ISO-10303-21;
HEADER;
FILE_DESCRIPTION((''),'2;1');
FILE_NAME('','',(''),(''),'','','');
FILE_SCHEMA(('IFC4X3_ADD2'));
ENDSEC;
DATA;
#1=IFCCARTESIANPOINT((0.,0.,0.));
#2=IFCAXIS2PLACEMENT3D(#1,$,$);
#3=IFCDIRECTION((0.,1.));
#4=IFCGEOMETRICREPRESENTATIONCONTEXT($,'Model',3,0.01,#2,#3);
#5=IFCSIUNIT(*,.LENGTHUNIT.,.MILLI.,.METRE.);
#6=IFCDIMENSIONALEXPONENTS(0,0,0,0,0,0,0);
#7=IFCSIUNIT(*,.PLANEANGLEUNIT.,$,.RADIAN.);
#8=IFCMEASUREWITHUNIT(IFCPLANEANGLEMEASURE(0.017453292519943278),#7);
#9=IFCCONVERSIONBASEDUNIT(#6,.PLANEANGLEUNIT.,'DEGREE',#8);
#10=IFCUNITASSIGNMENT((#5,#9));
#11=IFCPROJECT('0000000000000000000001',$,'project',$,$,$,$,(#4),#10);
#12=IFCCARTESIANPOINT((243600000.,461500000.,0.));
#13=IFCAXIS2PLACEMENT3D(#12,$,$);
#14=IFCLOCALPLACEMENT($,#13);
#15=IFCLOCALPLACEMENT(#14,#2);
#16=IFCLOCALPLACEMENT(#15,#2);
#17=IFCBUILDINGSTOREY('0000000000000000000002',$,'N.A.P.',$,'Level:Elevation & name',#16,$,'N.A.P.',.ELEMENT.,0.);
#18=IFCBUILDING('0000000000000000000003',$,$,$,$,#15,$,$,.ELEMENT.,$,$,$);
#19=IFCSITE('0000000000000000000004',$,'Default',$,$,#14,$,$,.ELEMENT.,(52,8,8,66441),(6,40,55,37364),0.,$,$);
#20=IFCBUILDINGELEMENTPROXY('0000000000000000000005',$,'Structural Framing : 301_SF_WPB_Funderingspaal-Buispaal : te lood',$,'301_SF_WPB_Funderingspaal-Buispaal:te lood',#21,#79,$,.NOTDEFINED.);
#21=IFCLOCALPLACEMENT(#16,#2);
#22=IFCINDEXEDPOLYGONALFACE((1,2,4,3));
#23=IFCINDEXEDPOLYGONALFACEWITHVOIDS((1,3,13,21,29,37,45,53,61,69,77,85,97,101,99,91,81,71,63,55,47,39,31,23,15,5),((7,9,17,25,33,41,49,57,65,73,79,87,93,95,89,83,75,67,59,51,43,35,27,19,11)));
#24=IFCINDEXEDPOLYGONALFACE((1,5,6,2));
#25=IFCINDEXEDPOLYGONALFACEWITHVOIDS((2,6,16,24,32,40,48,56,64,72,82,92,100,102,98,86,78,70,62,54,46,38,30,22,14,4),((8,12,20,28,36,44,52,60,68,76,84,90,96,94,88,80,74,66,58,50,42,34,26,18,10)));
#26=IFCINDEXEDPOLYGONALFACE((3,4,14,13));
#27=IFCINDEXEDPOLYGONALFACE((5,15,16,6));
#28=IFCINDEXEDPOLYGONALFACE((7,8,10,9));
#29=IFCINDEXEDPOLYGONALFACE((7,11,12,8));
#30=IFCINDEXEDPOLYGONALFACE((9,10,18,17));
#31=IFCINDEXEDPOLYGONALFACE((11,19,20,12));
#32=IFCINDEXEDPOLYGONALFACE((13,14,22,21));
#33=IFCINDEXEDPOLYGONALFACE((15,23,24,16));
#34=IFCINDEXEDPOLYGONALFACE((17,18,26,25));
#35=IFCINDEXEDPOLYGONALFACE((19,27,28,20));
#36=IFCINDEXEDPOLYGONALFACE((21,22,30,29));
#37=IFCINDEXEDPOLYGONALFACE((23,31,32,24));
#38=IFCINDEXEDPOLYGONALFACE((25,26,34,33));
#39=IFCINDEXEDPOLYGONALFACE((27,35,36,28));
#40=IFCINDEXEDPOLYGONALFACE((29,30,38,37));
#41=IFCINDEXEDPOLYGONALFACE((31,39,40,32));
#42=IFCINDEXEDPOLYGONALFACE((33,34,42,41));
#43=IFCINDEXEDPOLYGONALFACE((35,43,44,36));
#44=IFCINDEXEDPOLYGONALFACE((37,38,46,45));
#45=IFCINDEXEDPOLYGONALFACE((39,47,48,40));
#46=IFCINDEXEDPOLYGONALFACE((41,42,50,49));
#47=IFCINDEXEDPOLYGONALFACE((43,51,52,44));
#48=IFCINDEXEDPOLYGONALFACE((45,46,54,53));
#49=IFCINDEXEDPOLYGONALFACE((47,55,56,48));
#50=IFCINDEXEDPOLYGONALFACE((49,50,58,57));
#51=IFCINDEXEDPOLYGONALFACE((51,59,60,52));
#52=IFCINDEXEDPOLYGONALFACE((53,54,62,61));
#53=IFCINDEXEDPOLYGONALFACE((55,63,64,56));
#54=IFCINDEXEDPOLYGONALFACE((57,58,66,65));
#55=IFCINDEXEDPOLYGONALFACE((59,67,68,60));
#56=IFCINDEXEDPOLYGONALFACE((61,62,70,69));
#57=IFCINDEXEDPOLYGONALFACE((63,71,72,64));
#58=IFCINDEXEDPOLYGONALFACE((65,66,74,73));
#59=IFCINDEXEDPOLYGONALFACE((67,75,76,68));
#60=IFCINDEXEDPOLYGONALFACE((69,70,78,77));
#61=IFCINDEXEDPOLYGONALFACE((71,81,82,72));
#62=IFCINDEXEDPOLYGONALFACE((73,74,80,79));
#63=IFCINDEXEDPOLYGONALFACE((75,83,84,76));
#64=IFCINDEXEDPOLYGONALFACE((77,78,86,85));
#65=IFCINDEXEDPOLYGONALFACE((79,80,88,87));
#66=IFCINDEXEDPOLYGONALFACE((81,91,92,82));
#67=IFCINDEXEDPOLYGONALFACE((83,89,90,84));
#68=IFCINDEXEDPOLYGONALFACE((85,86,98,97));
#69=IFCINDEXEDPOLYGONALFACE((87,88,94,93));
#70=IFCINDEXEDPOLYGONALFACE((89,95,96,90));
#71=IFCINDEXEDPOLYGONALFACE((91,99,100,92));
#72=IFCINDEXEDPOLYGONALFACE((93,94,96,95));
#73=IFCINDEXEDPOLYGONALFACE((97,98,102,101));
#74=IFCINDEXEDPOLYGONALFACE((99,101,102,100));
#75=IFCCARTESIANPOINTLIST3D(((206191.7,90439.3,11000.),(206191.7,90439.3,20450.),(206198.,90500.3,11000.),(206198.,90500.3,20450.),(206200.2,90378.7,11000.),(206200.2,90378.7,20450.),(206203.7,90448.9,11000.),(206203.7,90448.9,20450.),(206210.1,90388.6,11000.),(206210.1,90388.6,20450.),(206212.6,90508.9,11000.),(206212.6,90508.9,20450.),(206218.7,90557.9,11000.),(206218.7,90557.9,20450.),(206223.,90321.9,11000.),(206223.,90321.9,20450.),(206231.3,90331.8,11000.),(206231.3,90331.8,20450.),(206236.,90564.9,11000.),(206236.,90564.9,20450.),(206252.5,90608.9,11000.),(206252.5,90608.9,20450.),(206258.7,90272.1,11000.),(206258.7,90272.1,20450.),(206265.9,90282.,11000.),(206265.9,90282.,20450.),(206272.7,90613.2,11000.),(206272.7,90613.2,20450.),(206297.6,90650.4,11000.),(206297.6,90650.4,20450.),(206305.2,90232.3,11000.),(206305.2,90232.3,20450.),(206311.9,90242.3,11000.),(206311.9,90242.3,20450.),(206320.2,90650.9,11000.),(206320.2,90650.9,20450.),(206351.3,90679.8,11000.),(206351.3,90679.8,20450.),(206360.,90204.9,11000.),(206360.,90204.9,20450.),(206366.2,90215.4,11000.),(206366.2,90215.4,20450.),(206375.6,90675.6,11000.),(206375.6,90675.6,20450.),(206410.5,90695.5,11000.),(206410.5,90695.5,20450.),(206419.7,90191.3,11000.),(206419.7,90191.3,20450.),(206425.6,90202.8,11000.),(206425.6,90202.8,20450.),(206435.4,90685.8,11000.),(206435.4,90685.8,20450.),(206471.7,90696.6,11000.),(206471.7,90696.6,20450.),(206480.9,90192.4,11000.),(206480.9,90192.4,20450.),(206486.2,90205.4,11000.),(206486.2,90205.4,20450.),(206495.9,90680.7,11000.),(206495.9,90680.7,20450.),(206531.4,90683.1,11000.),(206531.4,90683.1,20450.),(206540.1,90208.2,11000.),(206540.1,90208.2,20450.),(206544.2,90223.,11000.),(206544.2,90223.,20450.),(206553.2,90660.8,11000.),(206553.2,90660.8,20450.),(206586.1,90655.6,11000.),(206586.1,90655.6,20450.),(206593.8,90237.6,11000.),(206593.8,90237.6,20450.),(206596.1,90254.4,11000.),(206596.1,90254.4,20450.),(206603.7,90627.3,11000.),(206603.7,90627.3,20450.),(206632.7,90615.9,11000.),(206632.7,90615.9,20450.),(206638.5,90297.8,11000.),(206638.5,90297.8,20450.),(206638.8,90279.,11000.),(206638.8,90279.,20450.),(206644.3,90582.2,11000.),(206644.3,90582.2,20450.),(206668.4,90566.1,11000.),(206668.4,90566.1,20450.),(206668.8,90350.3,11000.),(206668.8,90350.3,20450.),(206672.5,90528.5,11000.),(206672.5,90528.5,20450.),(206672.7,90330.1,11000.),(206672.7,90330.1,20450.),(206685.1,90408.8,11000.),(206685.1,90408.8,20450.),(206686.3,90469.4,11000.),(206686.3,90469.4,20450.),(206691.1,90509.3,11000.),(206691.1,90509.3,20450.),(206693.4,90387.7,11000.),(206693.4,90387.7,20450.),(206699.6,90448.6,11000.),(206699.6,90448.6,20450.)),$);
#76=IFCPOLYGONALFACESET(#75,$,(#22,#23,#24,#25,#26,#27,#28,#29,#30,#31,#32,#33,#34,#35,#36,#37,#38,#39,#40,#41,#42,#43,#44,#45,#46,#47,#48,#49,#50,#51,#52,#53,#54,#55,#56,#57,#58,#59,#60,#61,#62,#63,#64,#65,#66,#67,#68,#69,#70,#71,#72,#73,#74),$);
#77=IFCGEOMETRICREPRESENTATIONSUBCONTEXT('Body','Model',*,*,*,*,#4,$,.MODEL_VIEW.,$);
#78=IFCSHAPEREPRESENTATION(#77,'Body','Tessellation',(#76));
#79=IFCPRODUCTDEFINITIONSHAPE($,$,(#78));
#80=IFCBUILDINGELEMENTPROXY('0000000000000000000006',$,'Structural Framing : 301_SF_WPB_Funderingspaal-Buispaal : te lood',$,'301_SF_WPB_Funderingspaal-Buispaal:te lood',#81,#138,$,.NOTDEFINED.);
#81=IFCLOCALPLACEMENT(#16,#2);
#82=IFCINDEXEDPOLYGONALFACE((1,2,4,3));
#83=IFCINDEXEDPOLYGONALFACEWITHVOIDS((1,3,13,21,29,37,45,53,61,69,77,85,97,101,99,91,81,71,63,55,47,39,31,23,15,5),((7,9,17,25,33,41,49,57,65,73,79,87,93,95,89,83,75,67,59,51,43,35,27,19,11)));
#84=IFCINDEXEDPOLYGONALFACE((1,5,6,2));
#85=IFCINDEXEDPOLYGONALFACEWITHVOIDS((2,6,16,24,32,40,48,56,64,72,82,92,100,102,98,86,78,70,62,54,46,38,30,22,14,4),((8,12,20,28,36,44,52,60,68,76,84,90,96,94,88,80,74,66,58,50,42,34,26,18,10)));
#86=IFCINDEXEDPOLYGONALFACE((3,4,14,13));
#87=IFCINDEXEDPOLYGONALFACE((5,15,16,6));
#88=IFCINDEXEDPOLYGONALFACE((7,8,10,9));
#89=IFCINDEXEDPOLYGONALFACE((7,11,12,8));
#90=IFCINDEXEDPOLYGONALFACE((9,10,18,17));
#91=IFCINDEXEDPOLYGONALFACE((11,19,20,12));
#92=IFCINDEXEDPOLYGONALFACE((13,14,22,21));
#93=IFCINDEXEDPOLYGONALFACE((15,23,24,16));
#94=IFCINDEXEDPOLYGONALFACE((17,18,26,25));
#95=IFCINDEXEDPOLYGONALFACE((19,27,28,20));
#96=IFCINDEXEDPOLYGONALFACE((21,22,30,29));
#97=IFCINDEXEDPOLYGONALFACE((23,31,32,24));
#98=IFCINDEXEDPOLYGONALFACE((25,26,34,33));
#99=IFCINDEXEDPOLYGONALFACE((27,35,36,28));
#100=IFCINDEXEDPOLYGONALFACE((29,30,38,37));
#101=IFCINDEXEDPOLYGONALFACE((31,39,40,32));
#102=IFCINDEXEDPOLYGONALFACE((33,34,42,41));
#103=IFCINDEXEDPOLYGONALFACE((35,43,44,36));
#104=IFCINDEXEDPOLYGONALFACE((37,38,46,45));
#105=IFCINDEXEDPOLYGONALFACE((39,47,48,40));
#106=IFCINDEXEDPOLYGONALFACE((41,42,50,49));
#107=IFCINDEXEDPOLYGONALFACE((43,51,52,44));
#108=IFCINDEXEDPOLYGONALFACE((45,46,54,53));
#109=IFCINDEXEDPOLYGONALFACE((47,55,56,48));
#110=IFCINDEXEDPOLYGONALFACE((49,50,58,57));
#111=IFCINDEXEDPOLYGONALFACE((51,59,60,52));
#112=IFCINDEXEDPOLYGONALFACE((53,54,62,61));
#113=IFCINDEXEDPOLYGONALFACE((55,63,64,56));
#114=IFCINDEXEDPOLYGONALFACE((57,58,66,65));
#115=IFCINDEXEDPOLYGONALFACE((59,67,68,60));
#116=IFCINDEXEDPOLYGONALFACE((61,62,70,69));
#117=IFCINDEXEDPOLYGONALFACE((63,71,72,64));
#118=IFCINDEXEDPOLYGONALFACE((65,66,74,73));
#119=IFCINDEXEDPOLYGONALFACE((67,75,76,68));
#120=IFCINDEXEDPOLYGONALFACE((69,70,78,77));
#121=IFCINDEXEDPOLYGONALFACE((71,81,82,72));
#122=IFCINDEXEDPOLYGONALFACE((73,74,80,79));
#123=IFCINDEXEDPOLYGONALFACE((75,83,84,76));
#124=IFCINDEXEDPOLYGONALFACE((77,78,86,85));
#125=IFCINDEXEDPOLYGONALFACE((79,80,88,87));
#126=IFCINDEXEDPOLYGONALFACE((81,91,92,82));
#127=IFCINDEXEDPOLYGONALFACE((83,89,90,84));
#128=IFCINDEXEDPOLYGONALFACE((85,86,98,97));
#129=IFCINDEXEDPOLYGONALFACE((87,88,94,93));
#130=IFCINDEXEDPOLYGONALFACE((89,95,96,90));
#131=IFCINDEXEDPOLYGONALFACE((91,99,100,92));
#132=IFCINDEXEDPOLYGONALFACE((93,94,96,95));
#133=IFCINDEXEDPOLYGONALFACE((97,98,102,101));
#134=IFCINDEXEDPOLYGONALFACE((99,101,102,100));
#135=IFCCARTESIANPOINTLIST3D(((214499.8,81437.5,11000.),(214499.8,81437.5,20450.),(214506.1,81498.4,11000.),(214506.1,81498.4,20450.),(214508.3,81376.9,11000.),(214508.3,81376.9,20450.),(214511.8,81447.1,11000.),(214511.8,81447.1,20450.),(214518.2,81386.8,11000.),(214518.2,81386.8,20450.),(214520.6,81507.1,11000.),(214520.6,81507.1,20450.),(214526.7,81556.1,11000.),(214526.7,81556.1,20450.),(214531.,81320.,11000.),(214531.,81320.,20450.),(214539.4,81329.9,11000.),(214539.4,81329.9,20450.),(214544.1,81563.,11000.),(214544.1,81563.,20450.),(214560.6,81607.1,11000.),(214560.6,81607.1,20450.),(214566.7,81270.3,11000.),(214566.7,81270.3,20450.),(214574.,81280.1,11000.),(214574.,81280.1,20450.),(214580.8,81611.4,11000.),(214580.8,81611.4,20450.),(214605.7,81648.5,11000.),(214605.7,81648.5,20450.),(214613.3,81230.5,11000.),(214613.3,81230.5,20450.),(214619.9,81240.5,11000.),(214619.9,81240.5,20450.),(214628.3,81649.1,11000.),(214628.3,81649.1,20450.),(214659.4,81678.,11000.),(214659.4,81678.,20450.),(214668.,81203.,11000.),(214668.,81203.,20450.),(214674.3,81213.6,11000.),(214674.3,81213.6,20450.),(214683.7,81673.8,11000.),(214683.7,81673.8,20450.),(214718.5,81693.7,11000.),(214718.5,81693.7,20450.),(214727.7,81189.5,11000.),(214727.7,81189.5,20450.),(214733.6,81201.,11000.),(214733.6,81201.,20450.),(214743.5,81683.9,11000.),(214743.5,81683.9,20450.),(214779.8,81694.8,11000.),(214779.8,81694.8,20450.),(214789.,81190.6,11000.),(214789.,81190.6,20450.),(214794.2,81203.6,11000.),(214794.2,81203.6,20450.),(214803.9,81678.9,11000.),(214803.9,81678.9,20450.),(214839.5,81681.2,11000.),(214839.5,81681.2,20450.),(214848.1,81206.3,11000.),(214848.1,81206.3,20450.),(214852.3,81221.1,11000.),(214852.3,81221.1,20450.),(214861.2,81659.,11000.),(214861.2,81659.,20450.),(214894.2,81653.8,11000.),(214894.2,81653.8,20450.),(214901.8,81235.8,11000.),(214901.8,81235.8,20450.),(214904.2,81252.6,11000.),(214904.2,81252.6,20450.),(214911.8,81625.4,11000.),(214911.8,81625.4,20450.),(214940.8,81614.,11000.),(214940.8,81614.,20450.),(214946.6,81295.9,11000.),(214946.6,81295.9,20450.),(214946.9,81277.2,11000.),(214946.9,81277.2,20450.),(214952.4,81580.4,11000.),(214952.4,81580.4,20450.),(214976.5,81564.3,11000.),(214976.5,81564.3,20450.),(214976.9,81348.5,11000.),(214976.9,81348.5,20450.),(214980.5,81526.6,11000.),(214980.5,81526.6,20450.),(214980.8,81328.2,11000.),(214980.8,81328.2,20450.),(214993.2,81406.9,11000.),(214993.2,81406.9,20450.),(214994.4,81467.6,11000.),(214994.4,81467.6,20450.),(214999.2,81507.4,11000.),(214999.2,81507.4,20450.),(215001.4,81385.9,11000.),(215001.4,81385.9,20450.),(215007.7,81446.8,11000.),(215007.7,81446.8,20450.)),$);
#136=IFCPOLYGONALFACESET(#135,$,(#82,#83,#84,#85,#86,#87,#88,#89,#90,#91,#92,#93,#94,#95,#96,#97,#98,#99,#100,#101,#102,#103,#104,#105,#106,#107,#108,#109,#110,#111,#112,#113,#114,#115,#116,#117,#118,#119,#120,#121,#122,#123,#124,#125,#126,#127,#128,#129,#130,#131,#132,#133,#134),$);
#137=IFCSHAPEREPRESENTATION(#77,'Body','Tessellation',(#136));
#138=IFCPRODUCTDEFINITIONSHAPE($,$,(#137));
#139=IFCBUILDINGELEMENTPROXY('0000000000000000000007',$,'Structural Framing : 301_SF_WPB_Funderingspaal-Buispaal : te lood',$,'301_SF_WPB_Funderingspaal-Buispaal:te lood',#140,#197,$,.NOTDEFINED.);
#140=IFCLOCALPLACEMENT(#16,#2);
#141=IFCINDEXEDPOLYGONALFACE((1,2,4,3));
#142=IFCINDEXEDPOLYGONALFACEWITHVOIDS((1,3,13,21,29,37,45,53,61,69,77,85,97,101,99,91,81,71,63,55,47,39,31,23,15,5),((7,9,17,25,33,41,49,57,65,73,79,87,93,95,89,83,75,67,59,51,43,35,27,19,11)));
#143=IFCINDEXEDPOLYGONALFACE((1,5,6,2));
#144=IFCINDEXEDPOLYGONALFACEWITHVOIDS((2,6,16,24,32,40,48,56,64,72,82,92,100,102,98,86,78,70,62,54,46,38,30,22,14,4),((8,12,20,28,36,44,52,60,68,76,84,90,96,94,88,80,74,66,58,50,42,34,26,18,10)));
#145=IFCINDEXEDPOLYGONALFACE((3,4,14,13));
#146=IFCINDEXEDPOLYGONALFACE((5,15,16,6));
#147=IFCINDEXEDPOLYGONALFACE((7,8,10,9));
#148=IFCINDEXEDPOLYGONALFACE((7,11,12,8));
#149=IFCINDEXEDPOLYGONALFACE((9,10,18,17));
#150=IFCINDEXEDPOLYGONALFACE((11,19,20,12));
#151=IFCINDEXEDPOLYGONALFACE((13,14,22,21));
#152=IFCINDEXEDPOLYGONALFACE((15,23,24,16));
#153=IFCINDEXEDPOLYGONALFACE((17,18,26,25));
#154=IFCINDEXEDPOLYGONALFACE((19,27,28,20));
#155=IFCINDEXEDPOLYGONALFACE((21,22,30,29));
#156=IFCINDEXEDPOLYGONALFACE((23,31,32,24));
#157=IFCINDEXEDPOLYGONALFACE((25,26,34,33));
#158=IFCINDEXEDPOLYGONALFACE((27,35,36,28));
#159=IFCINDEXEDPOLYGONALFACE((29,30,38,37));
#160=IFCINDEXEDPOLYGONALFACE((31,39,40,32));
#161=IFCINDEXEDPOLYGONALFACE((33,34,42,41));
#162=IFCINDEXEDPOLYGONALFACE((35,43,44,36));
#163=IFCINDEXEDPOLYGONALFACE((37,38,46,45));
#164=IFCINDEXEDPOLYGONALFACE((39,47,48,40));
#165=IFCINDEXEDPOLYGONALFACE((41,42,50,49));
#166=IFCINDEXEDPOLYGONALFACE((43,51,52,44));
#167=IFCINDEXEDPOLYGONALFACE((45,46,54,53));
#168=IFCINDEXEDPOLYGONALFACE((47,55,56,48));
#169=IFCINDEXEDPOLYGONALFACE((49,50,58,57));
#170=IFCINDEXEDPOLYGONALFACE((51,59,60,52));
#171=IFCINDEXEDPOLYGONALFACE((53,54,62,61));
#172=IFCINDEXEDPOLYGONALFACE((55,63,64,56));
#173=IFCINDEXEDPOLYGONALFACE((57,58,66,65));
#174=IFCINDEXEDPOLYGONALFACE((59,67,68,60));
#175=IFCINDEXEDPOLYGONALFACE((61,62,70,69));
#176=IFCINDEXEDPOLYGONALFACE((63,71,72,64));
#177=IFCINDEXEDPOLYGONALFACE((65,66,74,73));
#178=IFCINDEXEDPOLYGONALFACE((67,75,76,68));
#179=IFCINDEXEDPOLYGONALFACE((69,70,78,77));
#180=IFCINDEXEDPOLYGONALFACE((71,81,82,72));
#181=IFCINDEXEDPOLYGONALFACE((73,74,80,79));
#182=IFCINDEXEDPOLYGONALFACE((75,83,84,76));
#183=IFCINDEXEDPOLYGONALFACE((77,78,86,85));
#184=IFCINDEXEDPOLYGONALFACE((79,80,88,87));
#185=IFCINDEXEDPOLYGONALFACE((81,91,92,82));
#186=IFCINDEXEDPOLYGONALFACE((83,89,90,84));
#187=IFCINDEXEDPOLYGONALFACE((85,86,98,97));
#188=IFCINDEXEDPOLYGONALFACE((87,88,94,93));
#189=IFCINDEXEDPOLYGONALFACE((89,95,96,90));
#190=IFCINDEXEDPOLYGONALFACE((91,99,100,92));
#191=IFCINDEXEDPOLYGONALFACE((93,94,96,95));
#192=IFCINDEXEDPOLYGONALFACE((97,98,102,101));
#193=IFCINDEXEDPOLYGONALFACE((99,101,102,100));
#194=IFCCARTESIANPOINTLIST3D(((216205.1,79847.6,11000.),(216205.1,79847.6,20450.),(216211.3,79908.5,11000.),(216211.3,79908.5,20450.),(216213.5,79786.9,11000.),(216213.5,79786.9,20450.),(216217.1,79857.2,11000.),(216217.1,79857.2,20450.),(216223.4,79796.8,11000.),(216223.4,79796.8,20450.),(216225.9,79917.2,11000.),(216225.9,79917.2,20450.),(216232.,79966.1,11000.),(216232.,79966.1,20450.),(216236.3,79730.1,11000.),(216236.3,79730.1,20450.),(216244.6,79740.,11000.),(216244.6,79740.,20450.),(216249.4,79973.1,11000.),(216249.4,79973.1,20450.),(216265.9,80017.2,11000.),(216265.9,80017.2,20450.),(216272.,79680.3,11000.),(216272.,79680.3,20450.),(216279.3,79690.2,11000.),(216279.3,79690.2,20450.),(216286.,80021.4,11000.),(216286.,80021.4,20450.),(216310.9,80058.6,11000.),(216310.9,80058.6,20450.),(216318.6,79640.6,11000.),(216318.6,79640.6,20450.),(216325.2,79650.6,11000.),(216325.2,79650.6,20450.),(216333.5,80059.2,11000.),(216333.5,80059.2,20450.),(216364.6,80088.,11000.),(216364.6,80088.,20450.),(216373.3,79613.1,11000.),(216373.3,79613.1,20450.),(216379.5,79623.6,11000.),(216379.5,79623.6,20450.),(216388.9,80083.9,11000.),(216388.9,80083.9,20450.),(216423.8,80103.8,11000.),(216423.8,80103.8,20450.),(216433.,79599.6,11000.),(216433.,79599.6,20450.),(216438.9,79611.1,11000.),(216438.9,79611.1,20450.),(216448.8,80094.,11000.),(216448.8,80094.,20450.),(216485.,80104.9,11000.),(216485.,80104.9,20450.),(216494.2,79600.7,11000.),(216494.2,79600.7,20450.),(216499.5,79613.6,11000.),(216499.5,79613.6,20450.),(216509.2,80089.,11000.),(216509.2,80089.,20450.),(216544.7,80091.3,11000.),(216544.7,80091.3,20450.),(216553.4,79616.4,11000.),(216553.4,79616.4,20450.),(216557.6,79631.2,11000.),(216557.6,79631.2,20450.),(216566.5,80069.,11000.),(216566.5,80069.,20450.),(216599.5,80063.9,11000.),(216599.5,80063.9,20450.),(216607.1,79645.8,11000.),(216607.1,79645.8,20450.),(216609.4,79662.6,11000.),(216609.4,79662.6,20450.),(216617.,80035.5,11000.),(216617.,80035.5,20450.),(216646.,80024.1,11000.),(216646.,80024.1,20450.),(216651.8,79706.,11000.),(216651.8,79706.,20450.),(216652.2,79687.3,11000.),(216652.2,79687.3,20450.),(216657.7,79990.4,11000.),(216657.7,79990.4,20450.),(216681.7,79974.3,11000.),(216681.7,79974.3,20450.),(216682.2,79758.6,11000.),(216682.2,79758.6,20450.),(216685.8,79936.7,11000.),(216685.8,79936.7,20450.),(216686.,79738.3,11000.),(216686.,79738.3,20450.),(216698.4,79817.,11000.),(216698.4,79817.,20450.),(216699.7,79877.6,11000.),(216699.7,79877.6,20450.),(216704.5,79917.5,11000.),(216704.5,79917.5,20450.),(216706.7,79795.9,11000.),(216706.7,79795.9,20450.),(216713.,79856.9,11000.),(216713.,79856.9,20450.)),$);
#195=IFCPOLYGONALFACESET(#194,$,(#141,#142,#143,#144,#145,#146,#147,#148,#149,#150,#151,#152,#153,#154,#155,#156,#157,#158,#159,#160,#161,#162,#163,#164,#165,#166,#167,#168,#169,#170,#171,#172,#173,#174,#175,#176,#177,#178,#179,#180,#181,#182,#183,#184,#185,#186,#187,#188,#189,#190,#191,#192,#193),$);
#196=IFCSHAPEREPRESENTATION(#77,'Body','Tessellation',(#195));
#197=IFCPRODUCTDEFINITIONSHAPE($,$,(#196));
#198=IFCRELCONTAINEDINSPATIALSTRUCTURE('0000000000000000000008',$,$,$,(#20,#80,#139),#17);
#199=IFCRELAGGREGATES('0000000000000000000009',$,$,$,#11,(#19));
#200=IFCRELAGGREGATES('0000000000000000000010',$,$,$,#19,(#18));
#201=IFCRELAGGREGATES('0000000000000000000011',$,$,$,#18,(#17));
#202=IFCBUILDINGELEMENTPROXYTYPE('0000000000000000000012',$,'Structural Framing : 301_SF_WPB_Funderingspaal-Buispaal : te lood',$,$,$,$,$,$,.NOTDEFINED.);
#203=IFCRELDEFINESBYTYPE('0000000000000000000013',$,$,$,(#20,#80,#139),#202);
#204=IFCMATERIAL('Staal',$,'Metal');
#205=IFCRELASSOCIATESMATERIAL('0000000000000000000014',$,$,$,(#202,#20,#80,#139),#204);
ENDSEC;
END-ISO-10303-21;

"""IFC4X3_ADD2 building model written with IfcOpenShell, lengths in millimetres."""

from ifc_helpers import new_model, entity, si_unit, converted_unit, direction, frame, frame_2d, origin, place, context, subcontext, project, spatial, hollow_circle, extrude, source, transform, mapped, material, type_object, type_shapes, element, save


model = new_model("IFC4X3_ADD2")

# Units and contexts
model_context = context("Model", 3, precision=0.01, world=origin(), true_north=direction((0.0, 1.0)))
body_context = subcontext(model_context, "Body", "Model", "MODEL_VIEW")
ifc_project = project(units=[si_unit("LENGTHUNIT", "METRE", prefix="MILLI"), converted_unit("PLANEANGLEUNIT", "DEGREE", entity("IfcPlaneAngleMeasure", 0.017453292519943278), si_unit("PLANEANGLEUNIT", "RADIAN"), dimensions=[0, 0, 0, 0, 0, 0, 0])], contexts=[model_context])

# Site, building, storey
site_placement = place(None, frame((243600000.0, 461500000.0, 0.0)))
site = spatial("IfcSite", under=ifc_project, at=site_placement, Name="Default", CompositionType="ELEMENT", RefLatitude=(52, 8, 8, 66441), RefLongitude=(6, 40, 55, 37364), RefElevation=0.0)
building_placement = place(site_placement, origin())
building = spatial("IfcBuilding", under=site, at=building_placement, CompositionType="ELEMENT")
storey_placement = place(building_placement, origin())
storey = spatial("IfcBuildingStorey", under=building, at=storey_placement, Name="N.A.P.", ObjectType="Level:Elevation & name", LongName="N.A.P.", CompositionType="ELEMENT", Elevation=0.0)

# Building element proxies
ifc_material_1 = material(Name="Staal", Category="Metal")
building_element_proxy_type_1 = type_object("IfcBuildingElementProxyType", Name="Structural Framing : 301_SF_WPB_Funderingspaal-Buispaal : te lood", PredefinedType="NOTDEFINED", material=ifc_material_1)
shared_shape_1 = source(origin(), body_context, "Body", "SweptSolid", [
    extrude(hollow_circle(Radius=254.0, WallThickness=12.0, at=frame_2d((0.0, 0.0), x_axis=(1.0, 0.0))), frame((0.0, 0.0, 11000.0), z_axis=(0.0, 0.0, 1.0), x_axis=(0.0, -1.0, 0.0)), (0.0, 0.0, 1.0), 9450.0),
])
type_shapes(building_element_proxy_type_1, [shared_shape_1])
for number, where, z_axis, x_axis, name in (
    (1, (206445.7, 90444.0, 0.0), (0.0, 0.0, 1.0), (0.833209, -0.552959, 0.0), "Structural Framing : 301_SF_WPB_Funderingspaal-Buispaal : te lood"),
    (2, (214753.8, 81442.1, 0.0), (0.0, 0.0, 1.0), (0.833209, -0.552959, 0.0), "Structural Framing : 301_SF_WPB_Funderingspaal-Buispaal : te lood"),
    (3, (216459.0, 79852.2, 0.0), (0.0, 0.0, 1.0), (0.833209, -0.552959, 0.0), "Structural Framing : 301_SF_WPB_Funderingspaal-Buispaal : te lood"),
):
    element("IfcBuildingElementProxy", number, at=place(storey_placement, frame(where, z_axis=z_axis, x_axis=x_axis)), inside=storey, type_object=building_element_proxy_type_1, material=ifc_material_1, Name=name, ObjectType="301_SF_WPB_Funderingspaal-Buispaal:te lood", PredefinedType="NOTDEFINED", context=body_context, shape_type="MappedRepresentation", body=[
        mapped(shared_shape_1, transform((0.0, 0.0, 0.0), scale=1.0)),
    ])

save(model, "model.ifc")
